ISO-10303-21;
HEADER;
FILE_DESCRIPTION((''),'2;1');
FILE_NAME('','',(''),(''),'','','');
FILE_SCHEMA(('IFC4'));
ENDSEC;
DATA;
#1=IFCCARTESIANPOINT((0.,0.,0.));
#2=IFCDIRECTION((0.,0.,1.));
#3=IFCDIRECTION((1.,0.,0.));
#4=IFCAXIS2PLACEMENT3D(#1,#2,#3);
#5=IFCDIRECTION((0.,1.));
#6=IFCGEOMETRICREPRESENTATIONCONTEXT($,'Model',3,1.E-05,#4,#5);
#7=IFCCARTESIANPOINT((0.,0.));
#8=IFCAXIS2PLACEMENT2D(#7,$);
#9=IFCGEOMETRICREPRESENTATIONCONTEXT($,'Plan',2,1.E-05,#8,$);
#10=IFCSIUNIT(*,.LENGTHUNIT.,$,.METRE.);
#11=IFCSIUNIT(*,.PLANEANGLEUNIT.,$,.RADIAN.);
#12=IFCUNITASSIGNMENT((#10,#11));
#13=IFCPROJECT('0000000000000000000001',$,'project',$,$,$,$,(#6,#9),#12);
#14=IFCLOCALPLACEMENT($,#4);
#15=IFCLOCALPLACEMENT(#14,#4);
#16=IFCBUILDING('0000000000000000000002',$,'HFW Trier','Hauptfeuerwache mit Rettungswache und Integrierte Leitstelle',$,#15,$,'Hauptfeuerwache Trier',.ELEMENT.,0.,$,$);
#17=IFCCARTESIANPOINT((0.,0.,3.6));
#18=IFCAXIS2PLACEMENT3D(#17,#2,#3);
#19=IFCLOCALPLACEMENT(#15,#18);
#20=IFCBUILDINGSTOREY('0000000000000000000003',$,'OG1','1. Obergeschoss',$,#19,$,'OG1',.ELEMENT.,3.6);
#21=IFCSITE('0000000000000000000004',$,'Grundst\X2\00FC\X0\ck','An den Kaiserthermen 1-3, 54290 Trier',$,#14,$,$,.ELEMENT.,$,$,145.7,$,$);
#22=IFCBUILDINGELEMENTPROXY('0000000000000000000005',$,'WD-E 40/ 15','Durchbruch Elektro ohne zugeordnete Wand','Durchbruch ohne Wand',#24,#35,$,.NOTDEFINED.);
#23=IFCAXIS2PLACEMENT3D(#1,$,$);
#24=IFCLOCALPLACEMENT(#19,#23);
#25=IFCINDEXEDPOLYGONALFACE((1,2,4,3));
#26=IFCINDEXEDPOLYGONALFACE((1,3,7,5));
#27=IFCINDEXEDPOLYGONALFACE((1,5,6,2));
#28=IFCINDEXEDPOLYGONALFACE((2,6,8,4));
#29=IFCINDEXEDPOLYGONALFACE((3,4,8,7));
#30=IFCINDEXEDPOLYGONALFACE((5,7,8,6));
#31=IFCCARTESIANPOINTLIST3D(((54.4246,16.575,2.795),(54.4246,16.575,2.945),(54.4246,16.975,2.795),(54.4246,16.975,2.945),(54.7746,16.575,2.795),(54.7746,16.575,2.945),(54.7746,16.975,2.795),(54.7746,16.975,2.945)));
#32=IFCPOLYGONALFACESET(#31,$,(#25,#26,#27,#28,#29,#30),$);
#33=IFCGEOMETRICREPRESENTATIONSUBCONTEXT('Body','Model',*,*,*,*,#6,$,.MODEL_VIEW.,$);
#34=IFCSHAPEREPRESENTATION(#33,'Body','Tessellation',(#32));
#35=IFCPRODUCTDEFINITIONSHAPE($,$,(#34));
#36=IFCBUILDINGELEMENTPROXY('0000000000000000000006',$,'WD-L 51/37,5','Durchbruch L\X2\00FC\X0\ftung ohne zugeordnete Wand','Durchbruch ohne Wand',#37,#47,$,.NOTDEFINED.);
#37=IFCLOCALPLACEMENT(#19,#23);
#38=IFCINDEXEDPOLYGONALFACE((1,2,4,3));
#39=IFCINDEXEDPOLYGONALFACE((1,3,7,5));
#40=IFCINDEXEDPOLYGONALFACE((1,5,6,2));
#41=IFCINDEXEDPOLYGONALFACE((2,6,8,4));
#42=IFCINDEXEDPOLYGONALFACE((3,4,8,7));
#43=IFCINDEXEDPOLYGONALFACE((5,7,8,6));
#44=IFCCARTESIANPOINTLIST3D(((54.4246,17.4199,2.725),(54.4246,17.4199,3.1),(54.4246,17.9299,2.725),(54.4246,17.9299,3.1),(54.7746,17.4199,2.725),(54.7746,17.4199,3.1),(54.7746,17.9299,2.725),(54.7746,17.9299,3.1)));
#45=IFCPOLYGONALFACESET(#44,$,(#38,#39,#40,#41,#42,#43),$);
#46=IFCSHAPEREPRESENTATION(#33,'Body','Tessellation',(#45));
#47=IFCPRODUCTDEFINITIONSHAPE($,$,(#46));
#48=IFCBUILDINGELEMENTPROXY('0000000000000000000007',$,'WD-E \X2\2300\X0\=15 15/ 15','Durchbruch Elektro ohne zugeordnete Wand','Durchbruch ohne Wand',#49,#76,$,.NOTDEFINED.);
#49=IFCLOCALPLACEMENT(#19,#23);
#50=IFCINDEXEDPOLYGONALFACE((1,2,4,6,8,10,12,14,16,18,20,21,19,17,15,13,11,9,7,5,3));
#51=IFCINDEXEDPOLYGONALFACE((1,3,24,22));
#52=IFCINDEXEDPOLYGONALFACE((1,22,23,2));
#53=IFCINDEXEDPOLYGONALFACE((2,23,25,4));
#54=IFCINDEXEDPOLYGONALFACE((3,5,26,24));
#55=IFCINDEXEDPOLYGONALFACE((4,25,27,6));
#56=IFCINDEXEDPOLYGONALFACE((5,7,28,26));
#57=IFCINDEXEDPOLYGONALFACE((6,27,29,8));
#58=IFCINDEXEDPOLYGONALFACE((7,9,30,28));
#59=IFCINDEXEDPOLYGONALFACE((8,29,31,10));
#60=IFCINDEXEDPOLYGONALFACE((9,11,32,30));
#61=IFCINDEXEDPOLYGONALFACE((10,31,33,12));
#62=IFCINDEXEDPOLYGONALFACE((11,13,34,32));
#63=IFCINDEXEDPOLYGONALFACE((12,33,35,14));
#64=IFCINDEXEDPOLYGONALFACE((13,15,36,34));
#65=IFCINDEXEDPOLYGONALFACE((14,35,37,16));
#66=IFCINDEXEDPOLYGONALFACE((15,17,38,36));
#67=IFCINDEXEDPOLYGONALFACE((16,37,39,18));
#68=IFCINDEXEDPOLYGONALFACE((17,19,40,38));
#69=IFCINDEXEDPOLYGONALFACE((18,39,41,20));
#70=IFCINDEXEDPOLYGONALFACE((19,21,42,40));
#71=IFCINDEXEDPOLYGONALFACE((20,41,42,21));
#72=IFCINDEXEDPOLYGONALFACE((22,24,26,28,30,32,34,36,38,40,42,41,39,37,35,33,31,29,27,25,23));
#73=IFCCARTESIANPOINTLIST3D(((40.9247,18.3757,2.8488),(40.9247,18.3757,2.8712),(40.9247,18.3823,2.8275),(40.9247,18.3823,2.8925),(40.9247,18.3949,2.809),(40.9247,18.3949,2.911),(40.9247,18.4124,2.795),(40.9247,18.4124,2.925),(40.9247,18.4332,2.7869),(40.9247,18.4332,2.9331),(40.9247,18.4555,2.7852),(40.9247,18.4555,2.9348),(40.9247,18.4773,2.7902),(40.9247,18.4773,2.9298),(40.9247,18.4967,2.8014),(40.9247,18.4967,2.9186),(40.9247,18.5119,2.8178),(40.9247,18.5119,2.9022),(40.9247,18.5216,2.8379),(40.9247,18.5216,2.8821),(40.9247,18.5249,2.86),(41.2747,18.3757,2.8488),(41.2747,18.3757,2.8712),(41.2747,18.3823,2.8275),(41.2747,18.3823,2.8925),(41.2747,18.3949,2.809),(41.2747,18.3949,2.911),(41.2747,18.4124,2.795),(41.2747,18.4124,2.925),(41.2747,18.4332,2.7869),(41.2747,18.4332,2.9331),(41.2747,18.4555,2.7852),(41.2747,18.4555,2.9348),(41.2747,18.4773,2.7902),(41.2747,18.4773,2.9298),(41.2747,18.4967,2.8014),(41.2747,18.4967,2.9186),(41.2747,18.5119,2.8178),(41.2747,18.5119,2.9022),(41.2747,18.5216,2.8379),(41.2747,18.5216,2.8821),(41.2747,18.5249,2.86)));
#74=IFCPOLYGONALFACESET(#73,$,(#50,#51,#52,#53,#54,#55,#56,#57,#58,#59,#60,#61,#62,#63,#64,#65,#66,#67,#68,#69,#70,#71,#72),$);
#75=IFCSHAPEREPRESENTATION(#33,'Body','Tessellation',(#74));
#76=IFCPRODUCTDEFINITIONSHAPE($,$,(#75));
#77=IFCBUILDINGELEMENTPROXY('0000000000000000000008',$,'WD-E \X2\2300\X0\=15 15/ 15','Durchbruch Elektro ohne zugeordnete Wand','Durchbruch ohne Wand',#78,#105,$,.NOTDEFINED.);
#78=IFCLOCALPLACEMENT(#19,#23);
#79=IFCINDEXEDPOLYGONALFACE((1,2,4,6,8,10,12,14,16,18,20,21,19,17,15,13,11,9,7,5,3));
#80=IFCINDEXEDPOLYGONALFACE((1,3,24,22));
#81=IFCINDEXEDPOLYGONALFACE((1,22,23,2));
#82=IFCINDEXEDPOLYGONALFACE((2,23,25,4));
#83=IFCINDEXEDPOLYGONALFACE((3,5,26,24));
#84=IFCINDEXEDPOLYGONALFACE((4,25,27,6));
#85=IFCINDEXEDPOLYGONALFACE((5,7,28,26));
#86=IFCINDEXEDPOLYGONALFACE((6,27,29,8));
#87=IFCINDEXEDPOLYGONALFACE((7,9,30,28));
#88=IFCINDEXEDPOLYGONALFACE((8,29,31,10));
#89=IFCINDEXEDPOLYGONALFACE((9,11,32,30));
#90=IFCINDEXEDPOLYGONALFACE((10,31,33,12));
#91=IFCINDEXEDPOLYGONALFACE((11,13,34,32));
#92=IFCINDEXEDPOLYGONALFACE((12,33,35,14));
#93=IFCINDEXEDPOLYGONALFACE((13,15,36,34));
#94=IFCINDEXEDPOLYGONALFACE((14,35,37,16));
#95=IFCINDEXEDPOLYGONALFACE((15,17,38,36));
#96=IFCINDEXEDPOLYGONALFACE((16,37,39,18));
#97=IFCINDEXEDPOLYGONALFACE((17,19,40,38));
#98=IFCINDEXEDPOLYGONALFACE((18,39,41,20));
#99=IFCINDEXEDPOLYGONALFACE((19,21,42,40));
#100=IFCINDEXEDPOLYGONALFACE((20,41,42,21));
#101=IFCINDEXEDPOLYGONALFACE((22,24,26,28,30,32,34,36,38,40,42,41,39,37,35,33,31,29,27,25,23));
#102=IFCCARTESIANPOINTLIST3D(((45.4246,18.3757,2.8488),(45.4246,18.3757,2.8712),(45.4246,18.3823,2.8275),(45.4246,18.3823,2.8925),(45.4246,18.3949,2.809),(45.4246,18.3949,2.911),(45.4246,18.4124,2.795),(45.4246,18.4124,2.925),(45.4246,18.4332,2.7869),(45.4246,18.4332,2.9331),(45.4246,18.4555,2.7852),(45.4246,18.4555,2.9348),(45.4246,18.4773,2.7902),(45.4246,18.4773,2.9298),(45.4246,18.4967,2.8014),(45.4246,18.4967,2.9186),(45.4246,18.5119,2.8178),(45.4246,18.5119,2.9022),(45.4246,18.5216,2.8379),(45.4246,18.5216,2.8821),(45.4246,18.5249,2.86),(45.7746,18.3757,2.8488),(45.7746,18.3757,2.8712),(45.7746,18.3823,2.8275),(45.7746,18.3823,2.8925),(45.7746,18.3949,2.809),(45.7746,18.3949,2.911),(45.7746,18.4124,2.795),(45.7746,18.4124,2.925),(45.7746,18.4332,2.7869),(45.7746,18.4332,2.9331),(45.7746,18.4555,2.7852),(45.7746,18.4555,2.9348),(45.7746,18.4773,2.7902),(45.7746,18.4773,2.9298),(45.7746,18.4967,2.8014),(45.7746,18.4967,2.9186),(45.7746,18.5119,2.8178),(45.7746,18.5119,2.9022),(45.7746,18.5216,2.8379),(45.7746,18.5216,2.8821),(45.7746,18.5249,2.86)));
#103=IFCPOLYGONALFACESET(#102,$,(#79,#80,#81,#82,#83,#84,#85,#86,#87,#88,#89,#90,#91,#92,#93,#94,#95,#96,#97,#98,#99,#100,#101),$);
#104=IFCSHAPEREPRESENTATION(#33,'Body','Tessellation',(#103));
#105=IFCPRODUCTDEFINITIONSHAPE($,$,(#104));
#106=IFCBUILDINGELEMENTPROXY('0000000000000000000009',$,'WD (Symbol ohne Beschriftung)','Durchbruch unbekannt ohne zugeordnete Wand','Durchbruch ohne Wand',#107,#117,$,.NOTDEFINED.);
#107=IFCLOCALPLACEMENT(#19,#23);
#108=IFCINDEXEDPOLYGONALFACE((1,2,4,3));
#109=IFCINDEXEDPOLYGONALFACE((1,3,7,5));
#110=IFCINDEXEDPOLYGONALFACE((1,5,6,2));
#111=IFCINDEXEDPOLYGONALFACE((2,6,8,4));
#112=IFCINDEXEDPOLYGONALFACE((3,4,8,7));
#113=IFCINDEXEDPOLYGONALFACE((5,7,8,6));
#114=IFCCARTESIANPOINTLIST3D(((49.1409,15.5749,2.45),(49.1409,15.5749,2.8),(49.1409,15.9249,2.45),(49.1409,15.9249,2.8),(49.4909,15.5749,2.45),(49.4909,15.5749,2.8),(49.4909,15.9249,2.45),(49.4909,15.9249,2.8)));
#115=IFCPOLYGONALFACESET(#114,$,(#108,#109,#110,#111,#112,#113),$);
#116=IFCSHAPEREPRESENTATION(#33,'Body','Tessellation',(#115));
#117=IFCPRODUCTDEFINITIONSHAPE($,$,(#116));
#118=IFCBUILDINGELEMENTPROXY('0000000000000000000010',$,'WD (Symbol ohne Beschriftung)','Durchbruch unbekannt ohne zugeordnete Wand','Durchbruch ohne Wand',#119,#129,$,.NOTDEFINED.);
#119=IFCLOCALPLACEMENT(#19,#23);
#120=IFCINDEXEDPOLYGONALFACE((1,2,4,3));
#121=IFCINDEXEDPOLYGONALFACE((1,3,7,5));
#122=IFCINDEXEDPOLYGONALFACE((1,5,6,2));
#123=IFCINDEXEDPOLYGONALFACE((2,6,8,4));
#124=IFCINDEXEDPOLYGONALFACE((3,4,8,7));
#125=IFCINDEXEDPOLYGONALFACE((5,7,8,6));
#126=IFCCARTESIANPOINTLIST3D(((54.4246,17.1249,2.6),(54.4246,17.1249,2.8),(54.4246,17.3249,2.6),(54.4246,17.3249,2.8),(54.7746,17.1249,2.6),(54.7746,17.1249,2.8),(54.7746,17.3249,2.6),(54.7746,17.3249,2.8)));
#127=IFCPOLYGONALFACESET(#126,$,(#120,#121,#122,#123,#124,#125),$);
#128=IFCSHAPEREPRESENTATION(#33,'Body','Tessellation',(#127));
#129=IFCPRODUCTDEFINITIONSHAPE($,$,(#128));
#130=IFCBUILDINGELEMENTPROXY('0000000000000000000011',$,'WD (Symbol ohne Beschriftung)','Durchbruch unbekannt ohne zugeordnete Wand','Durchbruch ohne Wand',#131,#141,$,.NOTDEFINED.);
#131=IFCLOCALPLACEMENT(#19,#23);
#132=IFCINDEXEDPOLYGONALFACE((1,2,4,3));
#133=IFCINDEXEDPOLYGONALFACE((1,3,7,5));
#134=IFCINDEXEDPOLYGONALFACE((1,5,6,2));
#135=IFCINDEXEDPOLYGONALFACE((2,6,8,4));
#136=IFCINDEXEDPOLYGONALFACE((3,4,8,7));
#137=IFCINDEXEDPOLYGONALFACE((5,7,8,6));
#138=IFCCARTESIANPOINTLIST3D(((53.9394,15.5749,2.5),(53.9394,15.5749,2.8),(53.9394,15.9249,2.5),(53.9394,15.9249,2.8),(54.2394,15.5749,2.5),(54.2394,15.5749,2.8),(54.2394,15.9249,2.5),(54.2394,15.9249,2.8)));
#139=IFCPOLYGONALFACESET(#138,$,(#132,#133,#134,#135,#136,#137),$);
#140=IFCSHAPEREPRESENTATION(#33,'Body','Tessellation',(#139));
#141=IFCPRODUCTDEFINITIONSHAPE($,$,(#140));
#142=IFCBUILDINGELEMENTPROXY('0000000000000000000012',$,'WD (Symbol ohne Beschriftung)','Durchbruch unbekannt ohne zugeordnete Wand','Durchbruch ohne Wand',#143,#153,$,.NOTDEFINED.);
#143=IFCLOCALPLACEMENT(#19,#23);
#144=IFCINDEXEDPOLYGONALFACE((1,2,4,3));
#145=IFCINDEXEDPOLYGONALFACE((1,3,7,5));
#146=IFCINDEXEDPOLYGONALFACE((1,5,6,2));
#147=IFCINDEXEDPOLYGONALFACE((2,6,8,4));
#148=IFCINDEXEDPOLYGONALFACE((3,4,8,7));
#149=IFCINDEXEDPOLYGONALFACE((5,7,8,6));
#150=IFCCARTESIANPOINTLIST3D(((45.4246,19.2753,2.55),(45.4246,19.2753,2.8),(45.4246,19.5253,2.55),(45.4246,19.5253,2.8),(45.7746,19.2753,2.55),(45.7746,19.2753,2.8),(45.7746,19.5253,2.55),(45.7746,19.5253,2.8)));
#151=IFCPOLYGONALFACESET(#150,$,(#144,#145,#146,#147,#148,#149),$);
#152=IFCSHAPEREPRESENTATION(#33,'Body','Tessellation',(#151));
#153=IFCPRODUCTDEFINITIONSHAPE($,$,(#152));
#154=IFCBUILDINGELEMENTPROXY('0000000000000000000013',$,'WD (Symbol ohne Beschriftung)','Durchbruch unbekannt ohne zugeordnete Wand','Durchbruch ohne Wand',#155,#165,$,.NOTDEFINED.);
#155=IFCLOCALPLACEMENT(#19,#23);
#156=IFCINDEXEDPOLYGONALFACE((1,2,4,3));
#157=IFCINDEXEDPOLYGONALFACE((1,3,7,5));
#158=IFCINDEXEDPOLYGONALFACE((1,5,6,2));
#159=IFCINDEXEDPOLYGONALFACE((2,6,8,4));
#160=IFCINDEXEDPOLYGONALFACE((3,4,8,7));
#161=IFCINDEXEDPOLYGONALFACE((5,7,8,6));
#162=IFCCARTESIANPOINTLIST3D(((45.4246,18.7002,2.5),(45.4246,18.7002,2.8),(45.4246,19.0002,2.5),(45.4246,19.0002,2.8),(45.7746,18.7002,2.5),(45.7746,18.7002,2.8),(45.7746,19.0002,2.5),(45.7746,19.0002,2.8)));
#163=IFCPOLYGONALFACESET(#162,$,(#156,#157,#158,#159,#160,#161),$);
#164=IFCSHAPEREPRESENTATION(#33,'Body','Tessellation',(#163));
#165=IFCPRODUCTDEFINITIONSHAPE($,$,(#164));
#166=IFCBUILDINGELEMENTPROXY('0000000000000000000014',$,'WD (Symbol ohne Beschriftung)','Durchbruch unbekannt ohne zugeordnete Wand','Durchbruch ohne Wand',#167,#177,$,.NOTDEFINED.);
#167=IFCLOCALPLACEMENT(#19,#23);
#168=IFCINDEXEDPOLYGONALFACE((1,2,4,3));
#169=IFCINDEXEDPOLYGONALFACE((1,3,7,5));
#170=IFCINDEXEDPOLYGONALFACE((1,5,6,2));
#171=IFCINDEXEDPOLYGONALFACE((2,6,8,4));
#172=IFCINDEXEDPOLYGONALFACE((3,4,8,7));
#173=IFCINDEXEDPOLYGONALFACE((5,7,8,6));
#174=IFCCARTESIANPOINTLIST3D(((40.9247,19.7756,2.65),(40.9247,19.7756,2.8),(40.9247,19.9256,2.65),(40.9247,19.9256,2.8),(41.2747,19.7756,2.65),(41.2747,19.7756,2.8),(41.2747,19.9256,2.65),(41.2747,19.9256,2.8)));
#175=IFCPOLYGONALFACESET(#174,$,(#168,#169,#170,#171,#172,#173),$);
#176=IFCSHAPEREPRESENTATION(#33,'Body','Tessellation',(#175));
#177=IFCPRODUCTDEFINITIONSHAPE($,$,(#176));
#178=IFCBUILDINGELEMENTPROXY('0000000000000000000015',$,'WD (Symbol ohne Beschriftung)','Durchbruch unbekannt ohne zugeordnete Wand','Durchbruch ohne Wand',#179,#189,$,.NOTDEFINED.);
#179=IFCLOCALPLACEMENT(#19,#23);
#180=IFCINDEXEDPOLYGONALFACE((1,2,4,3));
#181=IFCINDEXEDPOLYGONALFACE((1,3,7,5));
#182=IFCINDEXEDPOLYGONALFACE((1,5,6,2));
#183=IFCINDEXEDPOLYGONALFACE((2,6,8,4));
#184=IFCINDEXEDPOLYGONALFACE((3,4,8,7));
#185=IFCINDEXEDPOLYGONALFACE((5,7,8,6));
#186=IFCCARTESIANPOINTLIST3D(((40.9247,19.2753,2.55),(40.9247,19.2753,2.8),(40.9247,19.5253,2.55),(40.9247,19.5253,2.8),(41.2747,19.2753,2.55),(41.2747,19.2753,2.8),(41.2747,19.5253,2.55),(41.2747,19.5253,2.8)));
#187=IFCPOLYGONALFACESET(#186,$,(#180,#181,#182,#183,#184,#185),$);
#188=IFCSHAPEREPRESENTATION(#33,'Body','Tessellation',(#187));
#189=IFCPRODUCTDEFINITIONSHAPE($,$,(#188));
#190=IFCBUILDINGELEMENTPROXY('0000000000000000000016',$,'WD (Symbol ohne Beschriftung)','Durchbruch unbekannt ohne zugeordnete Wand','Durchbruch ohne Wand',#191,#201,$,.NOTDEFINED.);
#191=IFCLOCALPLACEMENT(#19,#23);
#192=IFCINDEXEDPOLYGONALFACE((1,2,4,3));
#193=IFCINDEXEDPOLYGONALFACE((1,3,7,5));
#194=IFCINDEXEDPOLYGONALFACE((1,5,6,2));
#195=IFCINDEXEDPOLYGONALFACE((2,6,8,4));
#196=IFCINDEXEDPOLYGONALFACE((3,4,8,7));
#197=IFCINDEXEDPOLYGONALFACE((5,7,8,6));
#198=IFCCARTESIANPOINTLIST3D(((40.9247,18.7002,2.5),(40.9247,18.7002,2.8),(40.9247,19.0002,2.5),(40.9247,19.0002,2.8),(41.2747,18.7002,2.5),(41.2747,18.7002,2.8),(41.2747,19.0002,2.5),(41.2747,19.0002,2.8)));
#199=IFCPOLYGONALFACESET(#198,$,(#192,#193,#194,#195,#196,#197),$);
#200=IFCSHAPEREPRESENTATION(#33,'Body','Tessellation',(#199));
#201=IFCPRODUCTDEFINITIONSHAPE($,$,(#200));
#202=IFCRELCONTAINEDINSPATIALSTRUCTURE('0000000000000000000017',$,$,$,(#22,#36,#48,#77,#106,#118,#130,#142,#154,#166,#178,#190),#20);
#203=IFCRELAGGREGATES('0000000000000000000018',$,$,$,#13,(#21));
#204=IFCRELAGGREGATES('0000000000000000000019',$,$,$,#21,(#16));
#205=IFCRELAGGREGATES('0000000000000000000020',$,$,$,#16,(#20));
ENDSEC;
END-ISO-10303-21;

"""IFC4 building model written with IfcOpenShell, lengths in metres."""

from ifc_helpers import new_model, si_unit, direction, frame, origin_with_axes, origin_2d, place, context, subcontext, project, spatial, rectangle, circle, extrude, element, save


model = new_model("IFC4")

# Units and contexts
model_context = context("Model", 3, precision=1e-05, world=origin_with_axes(), true_north=direction((0.0, 1.0)))
plan_context = context("Plan", 2, precision=1e-05, world=origin_2d())
body_context = subcontext(model_context, "Body", "Model", "MODEL_VIEW")
ifc_project = project(units=[si_unit("LENGTHUNIT", "METRE"), si_unit("PLANEANGLEUNIT", "RADIAN")], contexts=[model_context, plan_context])

# Site, building, storey
site_placement = place(None, origin_with_axes())
site = spatial("IfcSite", under=ifc_project, at=site_placement, Name="Grundstück", Description="An den Kaiserthermen 1-3, 54290 Trier", CompositionType="ELEMENT", RefElevation=145.7)
building_placement = place(site_placement, origin_with_axes())
building = spatial("IfcBuilding", under=site, at=building_placement, Name="HFW Trier", Description="Hauptfeuerwache mit Rettungswache und Integrierte Leitstelle", LongName="Hauptfeuerwache Trier", CompositionType="ELEMENT", ElevationOfRefHeight=0.0)
storey_placement = place(building_placement, frame((0.0, 0.0, 3.6), z_axis=(0.0, 0.0, 1.0), x_axis=(1.0, 0.0, 0.0)))
storey = spatial("IfcBuildingStorey", under=building, at=storey_placement, Name="OG1", Description="1. Obergeschoss", LongName="OG1", CompositionType="ELEMENT", Elevation=3.6)

# Building element proxies
proxy_1_placement = place(storey_placement, frame((54.5996, 16.775, 2.795), z_axis=(0.0, 0.0, 1.0), x_axis=(0.0, 1.0, 0.0)))
element("IfcBuildingElementProxy", 1, at=proxy_1_placement, inside=storey, Name="WD-E 40/ 15", Description="Durchbruch Elektro ohne zugeordnete Wand", ObjectType="Durchbruch ohne Wand", PredefinedType="NOTDEFINED", context=body_context, shape_type="SweptSolid", body=[
    extrude(rectangle(XDim=0.4, YDim=0.35, at=origin_2d()), origin_with_axes(), (0.0, 0.0, 1.0), 0.15),
])
proxy_2_placement = place(storey_placement, frame((54.5996, 17.6749, 2.725), z_axis=(0.0, 0.0, 1.0), x_axis=(0.0, 1.0, 0.0)))
element("IfcBuildingElementProxy", 2, at=proxy_2_placement, inside=storey, Name="WD-L 51/37,5", Description="Durchbruch Lüftung ohne zugeordnete Wand", ObjectType="Durchbruch ohne Wand", PredefinedType="NOTDEFINED", context=body_context, shape_type="SweptSolid", body=[
    extrude(rectangle(XDim=0.51, YDim=0.35, at=origin_2d()), origin_with_axes(), (0.0, 0.0, 1.0), 0.375),
])
for number, where, z_axis, x_axis, name in (
    (3, (41.0997, 18.4499, 2.785), (0.0, 0.0, 1.0), (0.0, 1.0, 0.0), "WD-E ⌀=15 15/ 15"),
    (4, (45.5996, 18.4499, 2.785), (0.0, 0.0, 1.0), (0.0, 1.0, 0.0), "WD-E ⌀=15 15/ 15"),
):
    element("IfcBuildingElementProxy", number, at=place(storey_placement, frame(where, z_axis=z_axis, x_axis=x_axis)), inside=storey, Name=name, Description="Durchbruch Elektro ohne zugeordnete Wand", ObjectType="Durchbruch ohne Wand", PredefinedType="NOTDEFINED", context=body_context, shape_type="SweptSolid", body=[
        extrude(circle(Radius=0.075, at=origin_2d()), frame((0.0, -0.175, 0.075), z_axis=(0.0, 1.0, 0.0), x_axis=(1.0, 0.0, 0.0)), (0.0, 0.0, 1.0), 0.35),
    ])
proxy_3_placement = place(storey_placement, frame((49.3159, 15.7499, 2.45), z_axis=(0.0, 0.0, 1.0), x_axis=(1.0, 0.0, 0.0)))
element("IfcBuildingElementProxy", 5, at=proxy_3_placement, inside=storey, Name="WD (Symbol ohne Beschriftung)", Description="Durchbruch unbekannt ohne zugeordnete Wand", ObjectType="Durchbruch ohne Wand", PredefinedType="NOTDEFINED", context=body_context, shape_type="SweptSolid", body=[
    extrude(rectangle(XDim=0.35, YDim=0.35, at=origin_2d()), origin_with_axes(), (0.0, 0.0, 1.0), 0.35),
])
proxy_4_placement = place(storey_placement, frame((54.5996, 17.2249, 2.6), z_axis=(0.0, 0.0, 1.0), x_axis=(0.0, 1.0, 0.0)))
element("IfcBuildingElementProxy", 6, at=proxy_4_placement, inside=storey, Name="WD (Symbol ohne Beschriftung)", Description="Durchbruch unbekannt ohne zugeordnete Wand", ObjectType="Durchbruch ohne Wand", PredefinedType="NOTDEFINED", context=body_context, shape_type="SweptSolid", body=[
    extrude(rectangle(XDim=0.2, YDim=0.35, at=origin_2d()), origin_with_axes(), (0.0, 0.0, 1.0), 0.2),
])
proxy_5_placement = place(storey_placement, frame((54.0894, 15.7499, 2.5), z_axis=(0.0, 0.0, 1.0), x_axis=(1.0, 0.0, 0.0)))
element("IfcBuildingElementProxy", 7, at=proxy_5_placement, inside=storey, Name="WD (Symbol ohne Beschriftung)", Description="Durchbruch unbekannt ohne zugeordnete Wand", ObjectType="Durchbruch ohne Wand", PredefinedType="NOTDEFINED", context=body_context, shape_type="SweptSolid", body=[
    extrude(rectangle(XDim=0.3, YDim=0.35, at=origin_2d()), origin_with_axes(), (0.0, 0.0, 1.0), 0.3),
])
proxy_6_placement = place(storey_placement, frame((45.5996, 19.4003, 2.55), z_axis=(0.0, 0.0, 1.0), x_axis=(0.0, 1.0, 0.0)))
element("IfcBuildingElementProxy", 8, at=proxy_6_placement, inside=storey, Name="WD (Symbol ohne Beschriftung)", Description="Durchbruch unbekannt ohne zugeordnete Wand", ObjectType="Durchbruch ohne Wand", PredefinedType="NOTDEFINED", context=body_context, shape_type="SweptSolid", body=[
    extrude(rectangle(XDim=0.25, YDim=0.35, at=origin_2d()), origin_with_axes(), (0.0, 0.0, 1.0), 0.25),
])
proxy_7_placement = place(storey_placement, frame((45.5996, 18.8502, 2.5), z_axis=(0.0, 0.0, 1.0), x_axis=(0.0, 1.0, 0.0)))
element("IfcBuildingElementProxy", 9, at=proxy_7_placement, inside=storey, Name="WD (Symbol ohne Beschriftung)", Description="Durchbruch unbekannt ohne zugeordnete Wand", ObjectType="Durchbruch ohne Wand", PredefinedType="NOTDEFINED", context=body_context, shape_type="SweptSolid", body=[
    extrude(rectangle(XDim=0.3, YDim=0.35, at=origin_2d()), origin_with_axes(), (0.0, 0.0, 1.0), 0.3),
])
proxy_8_placement = place(storey_placement, frame((41.0997, 19.8506, 2.65), z_axis=(0.0, 0.0, 1.0), x_axis=(0.0, 1.0, 0.0)))
element("IfcBuildingElementProxy", 10, at=proxy_8_placement, inside=storey, Name="WD (Symbol ohne Beschriftung)", Description="Durchbruch unbekannt ohne zugeordnete Wand", ObjectType="Durchbruch ohne Wand", PredefinedType="NOTDEFINED", context=body_context, shape_type="SweptSolid", body=[
    extrude(rectangle(XDim=0.15, YDim=0.35, at=origin_2d()), origin_with_axes(), (0.0, 0.0, 1.0), 0.15),
])
proxy_9_placement = place(storey_placement, frame((41.0997, 19.4003, 2.55), z_axis=(0.0, 0.0, 1.0), x_axis=(0.0, 1.0, 0.0)))
element("IfcBuildingElementProxy", 11, at=proxy_9_placement, inside=storey, Name="WD (Symbol ohne Beschriftung)", Description="Durchbruch unbekannt ohne zugeordnete Wand", ObjectType="Durchbruch ohne Wand", PredefinedType="NOTDEFINED", context=body_context, shape_type="SweptSolid", body=[
    extrude(rectangle(XDim=0.25, YDim=0.35, at=origin_2d()), origin_with_axes(), (0.0, 0.0, 1.0), 0.25),
])
proxy_10_placement = place(storey_placement, frame((41.0997, 18.8502, 2.5), z_axis=(0.0, 0.0, 1.0), x_axis=(0.0, 1.0, 0.0)))
element("IfcBuildingElementProxy", 12, at=proxy_10_placement, inside=storey, Name="WD (Symbol ohne Beschriftung)", Description="Durchbruch unbekannt ohne zugeordnete Wand", ObjectType="Durchbruch ohne Wand", PredefinedType="NOTDEFINED", context=body_context, shape_type="SweptSolid", body=[
    extrude(rectangle(XDim=0.3, YDim=0.35, at=origin_2d()), origin_with_axes(), (0.0, 0.0, 1.0), 0.3),
])

save(model, "model.ifc")
